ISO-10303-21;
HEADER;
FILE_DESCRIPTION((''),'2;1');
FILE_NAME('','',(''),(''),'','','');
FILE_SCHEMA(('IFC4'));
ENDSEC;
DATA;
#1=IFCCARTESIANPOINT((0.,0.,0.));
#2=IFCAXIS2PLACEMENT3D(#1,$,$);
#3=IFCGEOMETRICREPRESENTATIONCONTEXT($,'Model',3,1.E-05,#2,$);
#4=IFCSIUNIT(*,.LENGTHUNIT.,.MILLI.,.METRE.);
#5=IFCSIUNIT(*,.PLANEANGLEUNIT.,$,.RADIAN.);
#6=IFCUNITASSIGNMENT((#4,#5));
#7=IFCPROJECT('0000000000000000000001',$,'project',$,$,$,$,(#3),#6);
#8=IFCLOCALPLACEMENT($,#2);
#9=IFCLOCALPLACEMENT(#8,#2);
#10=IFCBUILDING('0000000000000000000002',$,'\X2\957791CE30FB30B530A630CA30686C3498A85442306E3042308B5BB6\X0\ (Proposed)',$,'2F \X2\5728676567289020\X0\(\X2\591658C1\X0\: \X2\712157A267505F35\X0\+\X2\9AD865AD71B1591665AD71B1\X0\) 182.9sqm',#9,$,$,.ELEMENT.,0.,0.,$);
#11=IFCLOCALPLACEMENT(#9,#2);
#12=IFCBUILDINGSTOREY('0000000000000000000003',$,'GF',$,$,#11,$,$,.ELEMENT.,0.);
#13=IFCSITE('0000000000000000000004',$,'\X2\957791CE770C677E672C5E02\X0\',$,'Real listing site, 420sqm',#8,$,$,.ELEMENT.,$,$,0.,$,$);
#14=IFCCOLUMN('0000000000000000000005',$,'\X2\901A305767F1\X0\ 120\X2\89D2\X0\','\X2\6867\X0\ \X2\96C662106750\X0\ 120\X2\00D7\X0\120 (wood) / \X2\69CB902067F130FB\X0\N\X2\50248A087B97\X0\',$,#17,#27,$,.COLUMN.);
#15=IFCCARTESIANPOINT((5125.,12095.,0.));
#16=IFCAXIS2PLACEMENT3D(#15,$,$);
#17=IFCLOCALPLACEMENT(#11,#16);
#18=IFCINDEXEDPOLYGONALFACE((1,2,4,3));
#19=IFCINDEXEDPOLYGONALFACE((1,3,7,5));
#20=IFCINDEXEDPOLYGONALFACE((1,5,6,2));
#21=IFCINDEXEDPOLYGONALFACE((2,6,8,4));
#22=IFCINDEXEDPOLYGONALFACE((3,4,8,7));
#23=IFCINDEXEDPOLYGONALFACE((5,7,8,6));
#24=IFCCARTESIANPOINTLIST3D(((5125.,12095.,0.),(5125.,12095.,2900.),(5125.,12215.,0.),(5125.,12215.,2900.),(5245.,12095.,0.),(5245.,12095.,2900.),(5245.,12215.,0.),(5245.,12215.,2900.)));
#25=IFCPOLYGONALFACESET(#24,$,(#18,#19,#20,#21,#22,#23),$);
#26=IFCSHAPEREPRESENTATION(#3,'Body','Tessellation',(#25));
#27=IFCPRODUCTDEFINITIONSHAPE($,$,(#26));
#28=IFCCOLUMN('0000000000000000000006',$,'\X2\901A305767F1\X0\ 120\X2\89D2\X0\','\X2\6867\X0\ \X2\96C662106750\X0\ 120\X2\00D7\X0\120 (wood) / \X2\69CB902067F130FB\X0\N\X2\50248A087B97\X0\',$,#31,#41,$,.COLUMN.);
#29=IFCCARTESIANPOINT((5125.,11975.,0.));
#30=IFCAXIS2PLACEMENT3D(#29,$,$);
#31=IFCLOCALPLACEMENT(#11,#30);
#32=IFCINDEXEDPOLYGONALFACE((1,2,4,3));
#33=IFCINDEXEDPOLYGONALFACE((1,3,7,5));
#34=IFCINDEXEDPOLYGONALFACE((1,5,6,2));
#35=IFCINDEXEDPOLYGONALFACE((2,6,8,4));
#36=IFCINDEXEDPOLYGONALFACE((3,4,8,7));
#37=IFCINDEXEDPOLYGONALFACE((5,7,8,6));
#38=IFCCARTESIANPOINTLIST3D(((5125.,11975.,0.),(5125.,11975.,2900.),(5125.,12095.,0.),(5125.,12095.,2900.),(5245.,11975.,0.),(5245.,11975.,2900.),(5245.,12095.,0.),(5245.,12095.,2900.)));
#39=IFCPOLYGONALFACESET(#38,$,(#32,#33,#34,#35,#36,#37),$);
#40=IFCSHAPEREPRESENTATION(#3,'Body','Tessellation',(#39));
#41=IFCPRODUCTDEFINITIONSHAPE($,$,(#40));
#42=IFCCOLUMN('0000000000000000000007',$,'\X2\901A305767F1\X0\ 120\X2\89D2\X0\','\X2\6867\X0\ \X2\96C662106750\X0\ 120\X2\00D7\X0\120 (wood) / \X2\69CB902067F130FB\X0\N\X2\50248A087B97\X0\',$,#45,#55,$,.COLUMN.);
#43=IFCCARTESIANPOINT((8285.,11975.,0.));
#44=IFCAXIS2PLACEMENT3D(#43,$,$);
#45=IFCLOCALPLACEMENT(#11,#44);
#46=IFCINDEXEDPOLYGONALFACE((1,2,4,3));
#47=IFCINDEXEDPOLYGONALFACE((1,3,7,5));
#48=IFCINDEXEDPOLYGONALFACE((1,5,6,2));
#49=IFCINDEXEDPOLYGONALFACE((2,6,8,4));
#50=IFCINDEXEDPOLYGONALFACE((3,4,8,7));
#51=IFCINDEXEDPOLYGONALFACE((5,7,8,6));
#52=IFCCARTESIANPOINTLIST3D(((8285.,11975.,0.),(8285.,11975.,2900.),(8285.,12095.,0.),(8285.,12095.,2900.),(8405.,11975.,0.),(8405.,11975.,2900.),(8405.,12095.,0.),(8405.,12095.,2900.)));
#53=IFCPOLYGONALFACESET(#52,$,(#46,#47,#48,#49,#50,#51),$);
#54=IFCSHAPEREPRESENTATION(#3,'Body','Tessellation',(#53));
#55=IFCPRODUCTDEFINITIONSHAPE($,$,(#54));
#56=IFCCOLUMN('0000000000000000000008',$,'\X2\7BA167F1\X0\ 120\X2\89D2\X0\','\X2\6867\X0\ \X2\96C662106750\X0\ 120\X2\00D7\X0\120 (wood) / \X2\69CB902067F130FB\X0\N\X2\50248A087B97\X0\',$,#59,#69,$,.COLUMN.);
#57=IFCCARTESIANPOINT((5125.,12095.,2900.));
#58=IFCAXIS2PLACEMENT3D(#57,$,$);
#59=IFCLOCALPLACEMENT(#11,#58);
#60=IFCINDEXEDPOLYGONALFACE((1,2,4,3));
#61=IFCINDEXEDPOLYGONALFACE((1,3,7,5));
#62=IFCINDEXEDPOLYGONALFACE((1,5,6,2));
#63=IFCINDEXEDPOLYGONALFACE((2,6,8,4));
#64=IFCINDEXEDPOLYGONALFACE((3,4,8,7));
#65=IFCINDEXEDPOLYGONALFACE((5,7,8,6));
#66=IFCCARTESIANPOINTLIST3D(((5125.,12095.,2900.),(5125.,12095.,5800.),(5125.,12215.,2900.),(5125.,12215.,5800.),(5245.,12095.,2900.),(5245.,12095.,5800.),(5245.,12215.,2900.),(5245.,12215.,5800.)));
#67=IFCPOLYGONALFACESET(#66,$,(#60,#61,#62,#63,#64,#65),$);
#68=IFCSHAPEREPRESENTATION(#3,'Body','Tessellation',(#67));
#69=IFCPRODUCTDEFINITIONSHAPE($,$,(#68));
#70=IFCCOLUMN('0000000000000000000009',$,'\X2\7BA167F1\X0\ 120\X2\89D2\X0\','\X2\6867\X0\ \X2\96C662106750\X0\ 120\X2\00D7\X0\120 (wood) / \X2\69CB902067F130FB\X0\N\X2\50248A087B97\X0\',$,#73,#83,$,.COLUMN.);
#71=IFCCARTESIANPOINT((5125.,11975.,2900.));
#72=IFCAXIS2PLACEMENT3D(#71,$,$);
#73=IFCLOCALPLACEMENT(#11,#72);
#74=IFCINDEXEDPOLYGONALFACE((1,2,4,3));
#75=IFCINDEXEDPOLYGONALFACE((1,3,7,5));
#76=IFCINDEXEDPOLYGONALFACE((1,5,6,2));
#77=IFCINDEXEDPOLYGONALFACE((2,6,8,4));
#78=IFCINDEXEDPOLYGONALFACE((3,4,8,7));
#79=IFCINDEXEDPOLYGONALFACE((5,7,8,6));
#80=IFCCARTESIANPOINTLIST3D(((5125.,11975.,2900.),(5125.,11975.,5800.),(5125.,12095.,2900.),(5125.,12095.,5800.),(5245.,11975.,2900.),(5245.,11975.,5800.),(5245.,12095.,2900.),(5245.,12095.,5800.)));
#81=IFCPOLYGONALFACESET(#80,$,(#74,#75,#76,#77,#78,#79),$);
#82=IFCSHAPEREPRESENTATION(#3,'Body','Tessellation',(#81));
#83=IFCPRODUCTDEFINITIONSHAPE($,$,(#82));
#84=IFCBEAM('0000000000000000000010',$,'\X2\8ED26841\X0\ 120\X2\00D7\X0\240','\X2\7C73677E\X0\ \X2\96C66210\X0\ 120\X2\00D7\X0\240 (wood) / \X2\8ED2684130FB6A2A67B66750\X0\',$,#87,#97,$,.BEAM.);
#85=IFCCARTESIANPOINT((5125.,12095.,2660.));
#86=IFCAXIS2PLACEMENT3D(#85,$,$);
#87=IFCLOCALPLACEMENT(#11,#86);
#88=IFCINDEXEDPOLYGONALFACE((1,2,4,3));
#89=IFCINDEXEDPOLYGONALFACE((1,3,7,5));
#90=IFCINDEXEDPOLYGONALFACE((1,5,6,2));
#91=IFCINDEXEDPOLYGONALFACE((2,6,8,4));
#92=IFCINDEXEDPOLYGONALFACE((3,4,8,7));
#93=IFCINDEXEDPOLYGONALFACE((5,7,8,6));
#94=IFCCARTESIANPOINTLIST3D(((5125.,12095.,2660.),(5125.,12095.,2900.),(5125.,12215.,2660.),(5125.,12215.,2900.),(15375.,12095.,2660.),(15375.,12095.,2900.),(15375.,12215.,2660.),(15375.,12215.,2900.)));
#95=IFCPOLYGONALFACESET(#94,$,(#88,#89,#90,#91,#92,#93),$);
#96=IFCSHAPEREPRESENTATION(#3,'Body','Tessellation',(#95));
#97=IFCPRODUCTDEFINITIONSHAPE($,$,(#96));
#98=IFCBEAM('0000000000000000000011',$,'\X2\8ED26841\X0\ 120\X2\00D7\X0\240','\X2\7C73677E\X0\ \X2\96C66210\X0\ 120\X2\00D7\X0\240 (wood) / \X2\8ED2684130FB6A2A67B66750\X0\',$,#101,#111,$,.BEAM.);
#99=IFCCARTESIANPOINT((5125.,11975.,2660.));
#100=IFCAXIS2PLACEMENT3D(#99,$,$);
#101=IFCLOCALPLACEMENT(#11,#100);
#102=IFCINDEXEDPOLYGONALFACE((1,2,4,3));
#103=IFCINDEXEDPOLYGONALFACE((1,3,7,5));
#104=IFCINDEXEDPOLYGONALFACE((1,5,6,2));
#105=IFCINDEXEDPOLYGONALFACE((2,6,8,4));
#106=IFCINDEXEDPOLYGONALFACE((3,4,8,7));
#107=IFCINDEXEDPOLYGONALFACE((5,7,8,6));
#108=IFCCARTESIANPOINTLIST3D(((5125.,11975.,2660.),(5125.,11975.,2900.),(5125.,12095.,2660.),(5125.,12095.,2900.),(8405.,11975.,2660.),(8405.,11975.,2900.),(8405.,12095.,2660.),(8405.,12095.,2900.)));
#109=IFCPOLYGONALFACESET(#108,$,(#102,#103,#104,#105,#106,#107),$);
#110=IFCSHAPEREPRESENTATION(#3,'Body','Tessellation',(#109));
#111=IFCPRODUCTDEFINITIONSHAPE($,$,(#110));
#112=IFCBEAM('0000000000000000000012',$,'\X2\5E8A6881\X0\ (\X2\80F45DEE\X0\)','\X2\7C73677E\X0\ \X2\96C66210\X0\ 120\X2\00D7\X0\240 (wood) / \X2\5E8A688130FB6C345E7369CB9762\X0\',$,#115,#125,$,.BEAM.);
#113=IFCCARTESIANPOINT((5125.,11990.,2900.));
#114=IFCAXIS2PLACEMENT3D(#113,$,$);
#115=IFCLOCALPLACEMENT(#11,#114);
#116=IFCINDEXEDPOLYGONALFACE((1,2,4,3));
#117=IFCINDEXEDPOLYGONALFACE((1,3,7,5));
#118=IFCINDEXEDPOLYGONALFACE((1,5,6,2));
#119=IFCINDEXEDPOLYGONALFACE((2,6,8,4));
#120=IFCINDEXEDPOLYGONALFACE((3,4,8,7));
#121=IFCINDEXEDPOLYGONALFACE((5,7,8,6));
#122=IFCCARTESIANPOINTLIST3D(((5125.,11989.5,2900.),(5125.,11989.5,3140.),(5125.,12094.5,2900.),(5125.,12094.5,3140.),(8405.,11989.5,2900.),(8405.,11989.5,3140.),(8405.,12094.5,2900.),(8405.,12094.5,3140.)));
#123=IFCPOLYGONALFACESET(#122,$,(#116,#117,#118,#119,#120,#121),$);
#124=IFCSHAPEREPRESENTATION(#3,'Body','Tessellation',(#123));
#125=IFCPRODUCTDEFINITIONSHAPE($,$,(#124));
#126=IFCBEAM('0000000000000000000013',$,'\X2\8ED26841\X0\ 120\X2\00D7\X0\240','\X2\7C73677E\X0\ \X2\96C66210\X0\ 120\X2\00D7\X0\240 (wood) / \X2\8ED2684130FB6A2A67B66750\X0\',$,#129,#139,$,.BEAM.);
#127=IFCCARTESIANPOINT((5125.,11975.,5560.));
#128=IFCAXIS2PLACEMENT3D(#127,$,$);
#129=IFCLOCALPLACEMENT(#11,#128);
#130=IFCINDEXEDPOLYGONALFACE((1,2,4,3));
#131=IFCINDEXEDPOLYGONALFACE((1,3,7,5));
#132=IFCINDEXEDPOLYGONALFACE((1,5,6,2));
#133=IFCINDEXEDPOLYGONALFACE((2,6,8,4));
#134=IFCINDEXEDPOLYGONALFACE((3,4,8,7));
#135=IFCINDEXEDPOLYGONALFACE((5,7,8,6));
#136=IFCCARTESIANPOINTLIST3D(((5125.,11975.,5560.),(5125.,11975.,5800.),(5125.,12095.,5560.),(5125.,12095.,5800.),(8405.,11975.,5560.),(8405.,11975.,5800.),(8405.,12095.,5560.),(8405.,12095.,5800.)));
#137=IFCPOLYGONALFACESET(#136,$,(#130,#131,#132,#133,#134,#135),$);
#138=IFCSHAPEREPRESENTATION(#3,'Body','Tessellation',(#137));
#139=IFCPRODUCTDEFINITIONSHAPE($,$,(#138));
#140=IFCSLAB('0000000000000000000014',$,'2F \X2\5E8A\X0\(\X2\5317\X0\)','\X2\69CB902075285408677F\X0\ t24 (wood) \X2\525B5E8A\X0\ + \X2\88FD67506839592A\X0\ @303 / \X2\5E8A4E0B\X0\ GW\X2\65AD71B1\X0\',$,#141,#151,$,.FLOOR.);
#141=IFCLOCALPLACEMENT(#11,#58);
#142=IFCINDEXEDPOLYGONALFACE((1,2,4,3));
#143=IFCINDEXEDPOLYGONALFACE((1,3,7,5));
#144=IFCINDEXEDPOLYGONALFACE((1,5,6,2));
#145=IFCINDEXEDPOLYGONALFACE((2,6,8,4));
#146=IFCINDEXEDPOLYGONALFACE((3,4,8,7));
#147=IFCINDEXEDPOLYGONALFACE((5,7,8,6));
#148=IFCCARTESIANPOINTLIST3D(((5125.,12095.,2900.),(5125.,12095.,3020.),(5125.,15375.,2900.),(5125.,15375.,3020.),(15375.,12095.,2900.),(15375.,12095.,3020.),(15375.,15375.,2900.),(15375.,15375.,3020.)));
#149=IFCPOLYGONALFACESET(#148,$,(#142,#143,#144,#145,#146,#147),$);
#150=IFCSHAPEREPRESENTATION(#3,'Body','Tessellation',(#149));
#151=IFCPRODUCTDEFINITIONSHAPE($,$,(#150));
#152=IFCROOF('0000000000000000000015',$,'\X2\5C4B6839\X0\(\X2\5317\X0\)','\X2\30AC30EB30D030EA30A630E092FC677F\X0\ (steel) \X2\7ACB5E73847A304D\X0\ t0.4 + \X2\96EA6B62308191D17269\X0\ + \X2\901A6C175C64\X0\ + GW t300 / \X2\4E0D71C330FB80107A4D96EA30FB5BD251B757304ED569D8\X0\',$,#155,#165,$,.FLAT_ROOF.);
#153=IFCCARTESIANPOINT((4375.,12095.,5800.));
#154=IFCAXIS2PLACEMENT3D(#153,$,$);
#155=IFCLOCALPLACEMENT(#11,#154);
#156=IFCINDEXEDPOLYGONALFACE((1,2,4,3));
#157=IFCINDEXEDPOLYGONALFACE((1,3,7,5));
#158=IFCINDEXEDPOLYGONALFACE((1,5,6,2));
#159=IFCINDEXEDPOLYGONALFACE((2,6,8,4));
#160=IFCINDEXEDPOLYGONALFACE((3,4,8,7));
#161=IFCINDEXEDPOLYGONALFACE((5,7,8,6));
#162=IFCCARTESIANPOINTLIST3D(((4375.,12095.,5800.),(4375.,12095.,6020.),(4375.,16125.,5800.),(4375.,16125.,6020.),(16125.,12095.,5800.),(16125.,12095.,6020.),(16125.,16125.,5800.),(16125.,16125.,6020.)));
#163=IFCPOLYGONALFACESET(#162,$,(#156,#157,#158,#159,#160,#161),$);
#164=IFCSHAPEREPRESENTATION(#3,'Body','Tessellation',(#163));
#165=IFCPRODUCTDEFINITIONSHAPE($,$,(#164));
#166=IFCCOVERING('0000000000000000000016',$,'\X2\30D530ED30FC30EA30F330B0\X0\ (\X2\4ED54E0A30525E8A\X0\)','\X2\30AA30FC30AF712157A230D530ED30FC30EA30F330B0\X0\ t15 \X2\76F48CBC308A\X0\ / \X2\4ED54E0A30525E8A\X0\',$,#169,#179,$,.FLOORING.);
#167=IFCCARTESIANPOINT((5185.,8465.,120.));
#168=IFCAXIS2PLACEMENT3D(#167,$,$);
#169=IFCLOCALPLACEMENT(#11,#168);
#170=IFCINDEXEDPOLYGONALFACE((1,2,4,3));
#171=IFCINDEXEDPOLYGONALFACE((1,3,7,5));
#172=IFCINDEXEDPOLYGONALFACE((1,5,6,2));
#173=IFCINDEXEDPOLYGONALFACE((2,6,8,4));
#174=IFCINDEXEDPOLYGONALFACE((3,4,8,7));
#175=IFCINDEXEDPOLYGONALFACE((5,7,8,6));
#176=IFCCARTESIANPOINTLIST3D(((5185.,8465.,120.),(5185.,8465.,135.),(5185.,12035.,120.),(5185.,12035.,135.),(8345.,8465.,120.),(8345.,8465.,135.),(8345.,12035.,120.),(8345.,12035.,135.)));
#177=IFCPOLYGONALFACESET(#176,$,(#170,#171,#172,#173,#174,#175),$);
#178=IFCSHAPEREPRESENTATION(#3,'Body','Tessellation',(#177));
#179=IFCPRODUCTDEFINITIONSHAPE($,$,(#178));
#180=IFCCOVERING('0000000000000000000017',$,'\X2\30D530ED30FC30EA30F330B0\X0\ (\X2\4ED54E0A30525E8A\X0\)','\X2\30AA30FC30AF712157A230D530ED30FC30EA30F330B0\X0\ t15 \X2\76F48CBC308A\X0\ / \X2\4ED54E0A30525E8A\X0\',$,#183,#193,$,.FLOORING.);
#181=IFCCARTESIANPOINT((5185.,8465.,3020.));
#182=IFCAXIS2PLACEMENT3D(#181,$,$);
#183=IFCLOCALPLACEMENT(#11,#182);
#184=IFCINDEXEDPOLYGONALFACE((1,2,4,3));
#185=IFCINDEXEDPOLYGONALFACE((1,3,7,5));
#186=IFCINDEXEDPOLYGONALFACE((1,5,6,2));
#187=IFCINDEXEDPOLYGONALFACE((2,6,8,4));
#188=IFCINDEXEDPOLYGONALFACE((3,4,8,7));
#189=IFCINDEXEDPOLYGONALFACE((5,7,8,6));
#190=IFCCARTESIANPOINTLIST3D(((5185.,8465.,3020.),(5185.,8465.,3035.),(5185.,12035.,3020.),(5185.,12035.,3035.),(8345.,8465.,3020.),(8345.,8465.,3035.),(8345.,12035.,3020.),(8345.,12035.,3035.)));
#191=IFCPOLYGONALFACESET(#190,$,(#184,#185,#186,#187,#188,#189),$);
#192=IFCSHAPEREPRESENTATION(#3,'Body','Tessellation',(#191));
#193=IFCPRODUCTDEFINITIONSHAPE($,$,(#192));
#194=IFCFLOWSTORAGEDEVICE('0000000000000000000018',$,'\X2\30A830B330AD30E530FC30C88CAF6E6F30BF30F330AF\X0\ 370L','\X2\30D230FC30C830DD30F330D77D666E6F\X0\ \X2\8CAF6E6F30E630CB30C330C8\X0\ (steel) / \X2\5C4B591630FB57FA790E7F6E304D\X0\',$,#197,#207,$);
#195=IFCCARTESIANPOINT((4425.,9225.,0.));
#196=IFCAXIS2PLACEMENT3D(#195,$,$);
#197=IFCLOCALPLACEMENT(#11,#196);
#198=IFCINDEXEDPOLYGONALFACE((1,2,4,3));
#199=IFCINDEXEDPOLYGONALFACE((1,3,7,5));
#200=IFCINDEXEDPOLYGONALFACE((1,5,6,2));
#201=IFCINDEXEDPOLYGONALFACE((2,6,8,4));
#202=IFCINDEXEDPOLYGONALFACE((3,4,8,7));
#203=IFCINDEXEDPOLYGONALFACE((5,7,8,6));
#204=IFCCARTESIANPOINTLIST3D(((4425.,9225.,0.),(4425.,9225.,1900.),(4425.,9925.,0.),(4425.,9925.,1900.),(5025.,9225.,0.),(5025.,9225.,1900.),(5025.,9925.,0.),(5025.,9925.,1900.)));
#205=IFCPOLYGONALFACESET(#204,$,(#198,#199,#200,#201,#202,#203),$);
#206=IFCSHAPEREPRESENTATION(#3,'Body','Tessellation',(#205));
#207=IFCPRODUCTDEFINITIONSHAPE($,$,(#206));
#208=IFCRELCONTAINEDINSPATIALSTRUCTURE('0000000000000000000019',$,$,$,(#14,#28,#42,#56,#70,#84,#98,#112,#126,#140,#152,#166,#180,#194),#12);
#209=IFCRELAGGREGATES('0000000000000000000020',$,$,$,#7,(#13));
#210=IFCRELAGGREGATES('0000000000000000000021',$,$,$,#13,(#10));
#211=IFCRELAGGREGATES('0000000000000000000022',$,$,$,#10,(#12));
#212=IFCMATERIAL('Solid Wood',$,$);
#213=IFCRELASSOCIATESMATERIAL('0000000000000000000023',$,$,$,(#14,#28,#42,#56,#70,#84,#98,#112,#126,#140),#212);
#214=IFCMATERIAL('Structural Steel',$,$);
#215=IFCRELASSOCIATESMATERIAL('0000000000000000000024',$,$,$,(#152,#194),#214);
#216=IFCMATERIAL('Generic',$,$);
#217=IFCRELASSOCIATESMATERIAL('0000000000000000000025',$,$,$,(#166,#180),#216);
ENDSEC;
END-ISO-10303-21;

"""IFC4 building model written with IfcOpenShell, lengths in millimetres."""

from ifc_helpers import new_model, si_unit, frame, frame_2d, origin, place, context, project, spatial, rectangle, extrude, material, element, save


model = new_model("IFC4")

# Units and contexts
model_context = context("Model", 3, precision=1e-05, world=origin())
ifc_project = project(units=[si_unit("LENGTHUNIT", "METRE", prefix="MILLI"), si_unit("PLANEANGLEUNIT", "RADIAN")], contexts=[model_context])

# Site, building, storey
site_placement = place(None, origin())
site = spatial("IfcSite", under=ifc_project, at=site_placement, Name="長野県松本市", ObjectType="Real listing site, 420sqm", CompositionType="ELEMENT", RefElevation=0.0)
building_placement = place(site_placement, origin())
building = spatial("IfcBuilding", under=site, at=building_placement, Name="長野・サウナと水風呂のある家 (Proposed)", ObjectType="2F 在来木造(外壁: 無垢材張+高断熱外断熱) 182.9sqm", CompositionType="ELEMENT", ElevationOfRefHeight=0.0, ElevationOfTerrain=0.0)
storey_placement = place(building_placement, origin())
storey = spatial("IfcBuildingStorey", under=building, at=storey_placement, Name="GF", CompositionType="ELEMENT", Elevation=0.0)

# Columns
ifc_material_1 = material(Name="Solid Wood")
column_1_placement = place(storey_placement, frame((5125.0, 12095.0, 0.0)))
element("IfcColumn", 1, at=column_1_placement, inside=storey, material=ifc_material_1, Name="通し柱 120角", Description="桧 集成材 120×120 (wood) / 構造柱・N値計算", PredefinedType="COLUMN", context=model_context, shape_type="SweptSolid", body=[
    extrude(rectangle(XDim=120.0, YDim=120.0, at=frame_2d((60.0, 60.0))), frame((5125.0, 12095.0, 0.0)), (0.0, 0.0, 1.0), 2900.0),
])
column_2_placement = place(storey_placement, frame((5125.0, 11975.0, 0.0)))
element("IfcColumn", 2, at=column_2_placement, inside=storey, material=ifc_material_1, Name="通し柱 120角", Description="桧 集成材 120×120 (wood) / 構造柱・N値計算", PredefinedType="COLUMN", context=model_context, shape_type="SweptSolid", body=[
    extrude(rectangle(XDim=120.0, YDim=120.0, at=frame_2d((60.0, 60.0))), frame((5125.0, 11975.0, 0.0)), (0.0, 0.0, 1.0), 2900.0),
])
column_3_placement = place(storey_placement, frame((8285.0, 11975.0, 0.0)))
element("IfcColumn", 3, at=column_3_placement, inside=storey, material=ifc_material_1, Name="通し柱 120角", Description="桧 集成材 120×120 (wood) / 構造柱・N値計算", PredefinedType="COLUMN", context=model_context, shape_type="SweptSolid", body=[
    extrude(rectangle(XDim=120.0, YDim=120.0, at=frame_2d((60.0, 60.0))), frame((8285.0, 11975.0, 0.0)), (0.0, 0.0, 1.0), 2900.0),
])
column_4_placement = place(storey_placement, frame((5125.0, 12095.0, 2900.0)))
element("IfcColumn", 4, at=column_4_placement, inside=storey, material=ifc_material_1, Name="管柱 120角", Description="桧 集成材 120×120 (wood) / 構造柱・N値計算", PredefinedType="COLUMN", context=model_context, shape_type="SweptSolid", body=[
    extrude(rectangle(XDim=120.0, YDim=120.0, at=frame_2d((60.0, 60.0))), frame((5125.0, 12095.0, 2900.0)), (0.0, 0.0, 1.0), 2900.0),
])
column_5_placement = place(storey_placement, frame((5125.0, 11975.0, 2900.0)))
element("IfcColumn", 5, at=column_5_placement, inside=storey, material=ifc_material_1, Name="管柱 120角", Description="桧 集成材 120×120 (wood) / 構造柱・N値計算", PredefinedType="COLUMN", context=model_context, shape_type="SweptSolid", body=[
    extrude(rectangle(XDim=120.0, YDim=120.0, at=frame_2d((60.0, 60.0))), frame((5125.0, 11975.0, 2900.0)), (0.0, 0.0, 1.0), 2900.0),
])

# Beams
beam_1_placement = place(storey_placement, frame((5125.0, 12095.0, 2660.0)))
element("IfcBeam", 6, at=beam_1_placement, inside=storey, material=ifc_material_1, Name="軒桁 120×240", Description="米松 集成 120×240 (wood) / 軒桁・横架材", PredefinedType="BEAM", context=model_context, shape_type="SweptSolid", body=[
    extrude(rectangle(XDim=10250.0, YDim=120.0, at=frame_2d((5125.0, 60.0))), frame((5125.0, 12095.0, 2660.0)), (0.0, 0.0, 1.0), 240.0),
])
beam_2_placement = place(storey_placement, frame((5125.0, 11975.0, 2660.0)))
element("IfcBeam", 7, at=beam_2_placement, inside=storey, material=ifc_material_1, Name="軒桁 120×240", Description="米松 集成 120×240 (wood) / 軒桁・横架材", PredefinedType="BEAM", context=model_context, shape_type="SweptSolid", body=[
    extrude(rectangle(XDim=3280.0, YDim=120.0, at=frame_2d((1640.0, 60.0))), frame((5125.0, 11975.0, 2660.0)), (0.0, 0.0, 1.0), 240.0),
])
beam_3_placement = place(storey_placement, frame((5125.0, 11990.0, 2900.0)))
element("IfcBeam", 8, at=beam_3_placement, inside=storey, material=ifc_material_1, Name="床梁 (胴差)", Description="米松 集成 120×240 (wood) / 床梁・水平構面", PredefinedType="BEAM", context=model_context, shape_type="SweptSolid", body=[
    extrude(rectangle(XDim=3280.0, YDim=105.0, at=frame_2d((1640.0, 52.0))), frame((5125.0, 11990.0, 2900.0)), (0.0, 0.0, 1.0), 240.0),
])
beam_4_placement = place(storey_placement, frame((5125.0, 11975.0, 5560.0)))
element("IfcBeam", 9, at=beam_4_placement, inside=storey, material=ifc_material_1, Name="軒桁 120×240", Description="米松 集成 120×240 (wood) / 軒桁・横架材", PredefinedType="BEAM", context=model_context, shape_type="SweptSolid", body=[
    extrude(rectangle(XDim=3280.0, YDim=120.0, at=frame_2d((1640.0, 60.0))), frame((5125.0, 11975.0, 5560.0)), (0.0, 0.0, 1.0), 240.0),
])

# Slab
slab_1_placement = place(storey_placement, frame((5125.0, 12095.0, 2900.0)))
element("IfcSlab", 10, at=slab_1_placement, inside=storey, material=ifc_material_1, Name="2F 床(北)", Description="構造用合板 t24 (wood) 剛床 + 製材根太 @303 / 床下 GW断熱", PredefinedType="FLOOR", context=model_context, shape_type="SweptSolid", body=[
    extrude(rectangle(XDim=10250.0, YDim=3280.0, at=frame_2d((5125.0, 1640.0))), frame((5125.0, 12095.0, 2900.0)), (0.0, 0.0, 1.0), 120.0),
])

# Roof
ifc_material_2 = material(Name="Structural Steel")
for number, where, name in (
    (11, (4375.0, 12095.0, 5800.0), "屋根(北)"),
):
    element("IfcRoof", number, at=place(storey_placement, frame(where)), inside=storey, material=ifc_material_2, Name=name, Description="ガルバリウム鋼板 (steel) 立平葺き t0.4 + 雪止め金物 + 通気層 + GW t300 / 不燃・耐積雪・寒冷地仕様", PredefinedType="FLAT_ROOF", context=model_context, shape_type="SweptSolid", body=[
        extrude(rectangle(XDim=11750.0, YDim=4030.0, at=frame_2d((5875.0, 2015.0))), frame((4375.0, 12095.0, 5800.0)), (0.0, 0.0, 1.0), 220.0),
    ])

# Coverings
ifc_material_3 = material(Name="Generic")
covering_1_placement = place(storey_placement, frame((5185.0, 8465.0, 120.0)))
element("IfcCovering", 12, at=covering_1_placement, inside=storey, material=ifc_material_3, Name="フローリング (仕上げ床)", Description="オーク無垢フローリング t15 直貼り / 仕上げ床", PredefinedType="FLOORING", context=model_context, shape_type="SweptSolid", body=[
    extrude(rectangle(XDim=3160.0, YDim=3570.0, at=frame_2d((1580.0, 1785.0))), frame((5185.0, 8465.0, 120.0)), (0.0, 0.0, 1.0), 15.0),
])
covering_2_placement = place(storey_placement, frame((5185.0, 8465.0, 3020.0)))
element("IfcCovering", 13, at=covering_2_placement, inside=storey, material=ifc_material_3, Name="フローリング (仕上げ床)", Description="オーク無垢フローリング t15 直貼り / 仕上げ床", PredefinedType="FLOORING", context=model_context, shape_type="SweptSolid", body=[
    extrude(rectangle(XDim=3160.0, YDim=3570.0, at=frame_2d((1580.0, 1785.0))), frame((5185.0, 8465.0, 3020.0)), (0.0, 0.0, 1.0), 15.0),
])

# Flow storage device
flow_storage_device_placement = place(storey_placement, frame((4425.0, 9225.0, 0.0)))
element("IfcFlowStorageDevice", 14, at=flow_storage_device_placement, inside=storey, material=ifc_material_2, Name="エコキュート貯湯タンク 370L", Description="ヒートポンプ給湯 貯湯ユニット (steel) / 屋外・基礎置き", context=model_context, shape_type="SweptSolid", body=[
    extrude(rectangle(XDim=600.0, YDim=700.0, at=frame_2d((300.0, 350.0))), frame((4425.0, 9225.0, 0.0)), (0.0, 0.0, 1.0), 1900.0),
])

save(model, "model.ifc")
